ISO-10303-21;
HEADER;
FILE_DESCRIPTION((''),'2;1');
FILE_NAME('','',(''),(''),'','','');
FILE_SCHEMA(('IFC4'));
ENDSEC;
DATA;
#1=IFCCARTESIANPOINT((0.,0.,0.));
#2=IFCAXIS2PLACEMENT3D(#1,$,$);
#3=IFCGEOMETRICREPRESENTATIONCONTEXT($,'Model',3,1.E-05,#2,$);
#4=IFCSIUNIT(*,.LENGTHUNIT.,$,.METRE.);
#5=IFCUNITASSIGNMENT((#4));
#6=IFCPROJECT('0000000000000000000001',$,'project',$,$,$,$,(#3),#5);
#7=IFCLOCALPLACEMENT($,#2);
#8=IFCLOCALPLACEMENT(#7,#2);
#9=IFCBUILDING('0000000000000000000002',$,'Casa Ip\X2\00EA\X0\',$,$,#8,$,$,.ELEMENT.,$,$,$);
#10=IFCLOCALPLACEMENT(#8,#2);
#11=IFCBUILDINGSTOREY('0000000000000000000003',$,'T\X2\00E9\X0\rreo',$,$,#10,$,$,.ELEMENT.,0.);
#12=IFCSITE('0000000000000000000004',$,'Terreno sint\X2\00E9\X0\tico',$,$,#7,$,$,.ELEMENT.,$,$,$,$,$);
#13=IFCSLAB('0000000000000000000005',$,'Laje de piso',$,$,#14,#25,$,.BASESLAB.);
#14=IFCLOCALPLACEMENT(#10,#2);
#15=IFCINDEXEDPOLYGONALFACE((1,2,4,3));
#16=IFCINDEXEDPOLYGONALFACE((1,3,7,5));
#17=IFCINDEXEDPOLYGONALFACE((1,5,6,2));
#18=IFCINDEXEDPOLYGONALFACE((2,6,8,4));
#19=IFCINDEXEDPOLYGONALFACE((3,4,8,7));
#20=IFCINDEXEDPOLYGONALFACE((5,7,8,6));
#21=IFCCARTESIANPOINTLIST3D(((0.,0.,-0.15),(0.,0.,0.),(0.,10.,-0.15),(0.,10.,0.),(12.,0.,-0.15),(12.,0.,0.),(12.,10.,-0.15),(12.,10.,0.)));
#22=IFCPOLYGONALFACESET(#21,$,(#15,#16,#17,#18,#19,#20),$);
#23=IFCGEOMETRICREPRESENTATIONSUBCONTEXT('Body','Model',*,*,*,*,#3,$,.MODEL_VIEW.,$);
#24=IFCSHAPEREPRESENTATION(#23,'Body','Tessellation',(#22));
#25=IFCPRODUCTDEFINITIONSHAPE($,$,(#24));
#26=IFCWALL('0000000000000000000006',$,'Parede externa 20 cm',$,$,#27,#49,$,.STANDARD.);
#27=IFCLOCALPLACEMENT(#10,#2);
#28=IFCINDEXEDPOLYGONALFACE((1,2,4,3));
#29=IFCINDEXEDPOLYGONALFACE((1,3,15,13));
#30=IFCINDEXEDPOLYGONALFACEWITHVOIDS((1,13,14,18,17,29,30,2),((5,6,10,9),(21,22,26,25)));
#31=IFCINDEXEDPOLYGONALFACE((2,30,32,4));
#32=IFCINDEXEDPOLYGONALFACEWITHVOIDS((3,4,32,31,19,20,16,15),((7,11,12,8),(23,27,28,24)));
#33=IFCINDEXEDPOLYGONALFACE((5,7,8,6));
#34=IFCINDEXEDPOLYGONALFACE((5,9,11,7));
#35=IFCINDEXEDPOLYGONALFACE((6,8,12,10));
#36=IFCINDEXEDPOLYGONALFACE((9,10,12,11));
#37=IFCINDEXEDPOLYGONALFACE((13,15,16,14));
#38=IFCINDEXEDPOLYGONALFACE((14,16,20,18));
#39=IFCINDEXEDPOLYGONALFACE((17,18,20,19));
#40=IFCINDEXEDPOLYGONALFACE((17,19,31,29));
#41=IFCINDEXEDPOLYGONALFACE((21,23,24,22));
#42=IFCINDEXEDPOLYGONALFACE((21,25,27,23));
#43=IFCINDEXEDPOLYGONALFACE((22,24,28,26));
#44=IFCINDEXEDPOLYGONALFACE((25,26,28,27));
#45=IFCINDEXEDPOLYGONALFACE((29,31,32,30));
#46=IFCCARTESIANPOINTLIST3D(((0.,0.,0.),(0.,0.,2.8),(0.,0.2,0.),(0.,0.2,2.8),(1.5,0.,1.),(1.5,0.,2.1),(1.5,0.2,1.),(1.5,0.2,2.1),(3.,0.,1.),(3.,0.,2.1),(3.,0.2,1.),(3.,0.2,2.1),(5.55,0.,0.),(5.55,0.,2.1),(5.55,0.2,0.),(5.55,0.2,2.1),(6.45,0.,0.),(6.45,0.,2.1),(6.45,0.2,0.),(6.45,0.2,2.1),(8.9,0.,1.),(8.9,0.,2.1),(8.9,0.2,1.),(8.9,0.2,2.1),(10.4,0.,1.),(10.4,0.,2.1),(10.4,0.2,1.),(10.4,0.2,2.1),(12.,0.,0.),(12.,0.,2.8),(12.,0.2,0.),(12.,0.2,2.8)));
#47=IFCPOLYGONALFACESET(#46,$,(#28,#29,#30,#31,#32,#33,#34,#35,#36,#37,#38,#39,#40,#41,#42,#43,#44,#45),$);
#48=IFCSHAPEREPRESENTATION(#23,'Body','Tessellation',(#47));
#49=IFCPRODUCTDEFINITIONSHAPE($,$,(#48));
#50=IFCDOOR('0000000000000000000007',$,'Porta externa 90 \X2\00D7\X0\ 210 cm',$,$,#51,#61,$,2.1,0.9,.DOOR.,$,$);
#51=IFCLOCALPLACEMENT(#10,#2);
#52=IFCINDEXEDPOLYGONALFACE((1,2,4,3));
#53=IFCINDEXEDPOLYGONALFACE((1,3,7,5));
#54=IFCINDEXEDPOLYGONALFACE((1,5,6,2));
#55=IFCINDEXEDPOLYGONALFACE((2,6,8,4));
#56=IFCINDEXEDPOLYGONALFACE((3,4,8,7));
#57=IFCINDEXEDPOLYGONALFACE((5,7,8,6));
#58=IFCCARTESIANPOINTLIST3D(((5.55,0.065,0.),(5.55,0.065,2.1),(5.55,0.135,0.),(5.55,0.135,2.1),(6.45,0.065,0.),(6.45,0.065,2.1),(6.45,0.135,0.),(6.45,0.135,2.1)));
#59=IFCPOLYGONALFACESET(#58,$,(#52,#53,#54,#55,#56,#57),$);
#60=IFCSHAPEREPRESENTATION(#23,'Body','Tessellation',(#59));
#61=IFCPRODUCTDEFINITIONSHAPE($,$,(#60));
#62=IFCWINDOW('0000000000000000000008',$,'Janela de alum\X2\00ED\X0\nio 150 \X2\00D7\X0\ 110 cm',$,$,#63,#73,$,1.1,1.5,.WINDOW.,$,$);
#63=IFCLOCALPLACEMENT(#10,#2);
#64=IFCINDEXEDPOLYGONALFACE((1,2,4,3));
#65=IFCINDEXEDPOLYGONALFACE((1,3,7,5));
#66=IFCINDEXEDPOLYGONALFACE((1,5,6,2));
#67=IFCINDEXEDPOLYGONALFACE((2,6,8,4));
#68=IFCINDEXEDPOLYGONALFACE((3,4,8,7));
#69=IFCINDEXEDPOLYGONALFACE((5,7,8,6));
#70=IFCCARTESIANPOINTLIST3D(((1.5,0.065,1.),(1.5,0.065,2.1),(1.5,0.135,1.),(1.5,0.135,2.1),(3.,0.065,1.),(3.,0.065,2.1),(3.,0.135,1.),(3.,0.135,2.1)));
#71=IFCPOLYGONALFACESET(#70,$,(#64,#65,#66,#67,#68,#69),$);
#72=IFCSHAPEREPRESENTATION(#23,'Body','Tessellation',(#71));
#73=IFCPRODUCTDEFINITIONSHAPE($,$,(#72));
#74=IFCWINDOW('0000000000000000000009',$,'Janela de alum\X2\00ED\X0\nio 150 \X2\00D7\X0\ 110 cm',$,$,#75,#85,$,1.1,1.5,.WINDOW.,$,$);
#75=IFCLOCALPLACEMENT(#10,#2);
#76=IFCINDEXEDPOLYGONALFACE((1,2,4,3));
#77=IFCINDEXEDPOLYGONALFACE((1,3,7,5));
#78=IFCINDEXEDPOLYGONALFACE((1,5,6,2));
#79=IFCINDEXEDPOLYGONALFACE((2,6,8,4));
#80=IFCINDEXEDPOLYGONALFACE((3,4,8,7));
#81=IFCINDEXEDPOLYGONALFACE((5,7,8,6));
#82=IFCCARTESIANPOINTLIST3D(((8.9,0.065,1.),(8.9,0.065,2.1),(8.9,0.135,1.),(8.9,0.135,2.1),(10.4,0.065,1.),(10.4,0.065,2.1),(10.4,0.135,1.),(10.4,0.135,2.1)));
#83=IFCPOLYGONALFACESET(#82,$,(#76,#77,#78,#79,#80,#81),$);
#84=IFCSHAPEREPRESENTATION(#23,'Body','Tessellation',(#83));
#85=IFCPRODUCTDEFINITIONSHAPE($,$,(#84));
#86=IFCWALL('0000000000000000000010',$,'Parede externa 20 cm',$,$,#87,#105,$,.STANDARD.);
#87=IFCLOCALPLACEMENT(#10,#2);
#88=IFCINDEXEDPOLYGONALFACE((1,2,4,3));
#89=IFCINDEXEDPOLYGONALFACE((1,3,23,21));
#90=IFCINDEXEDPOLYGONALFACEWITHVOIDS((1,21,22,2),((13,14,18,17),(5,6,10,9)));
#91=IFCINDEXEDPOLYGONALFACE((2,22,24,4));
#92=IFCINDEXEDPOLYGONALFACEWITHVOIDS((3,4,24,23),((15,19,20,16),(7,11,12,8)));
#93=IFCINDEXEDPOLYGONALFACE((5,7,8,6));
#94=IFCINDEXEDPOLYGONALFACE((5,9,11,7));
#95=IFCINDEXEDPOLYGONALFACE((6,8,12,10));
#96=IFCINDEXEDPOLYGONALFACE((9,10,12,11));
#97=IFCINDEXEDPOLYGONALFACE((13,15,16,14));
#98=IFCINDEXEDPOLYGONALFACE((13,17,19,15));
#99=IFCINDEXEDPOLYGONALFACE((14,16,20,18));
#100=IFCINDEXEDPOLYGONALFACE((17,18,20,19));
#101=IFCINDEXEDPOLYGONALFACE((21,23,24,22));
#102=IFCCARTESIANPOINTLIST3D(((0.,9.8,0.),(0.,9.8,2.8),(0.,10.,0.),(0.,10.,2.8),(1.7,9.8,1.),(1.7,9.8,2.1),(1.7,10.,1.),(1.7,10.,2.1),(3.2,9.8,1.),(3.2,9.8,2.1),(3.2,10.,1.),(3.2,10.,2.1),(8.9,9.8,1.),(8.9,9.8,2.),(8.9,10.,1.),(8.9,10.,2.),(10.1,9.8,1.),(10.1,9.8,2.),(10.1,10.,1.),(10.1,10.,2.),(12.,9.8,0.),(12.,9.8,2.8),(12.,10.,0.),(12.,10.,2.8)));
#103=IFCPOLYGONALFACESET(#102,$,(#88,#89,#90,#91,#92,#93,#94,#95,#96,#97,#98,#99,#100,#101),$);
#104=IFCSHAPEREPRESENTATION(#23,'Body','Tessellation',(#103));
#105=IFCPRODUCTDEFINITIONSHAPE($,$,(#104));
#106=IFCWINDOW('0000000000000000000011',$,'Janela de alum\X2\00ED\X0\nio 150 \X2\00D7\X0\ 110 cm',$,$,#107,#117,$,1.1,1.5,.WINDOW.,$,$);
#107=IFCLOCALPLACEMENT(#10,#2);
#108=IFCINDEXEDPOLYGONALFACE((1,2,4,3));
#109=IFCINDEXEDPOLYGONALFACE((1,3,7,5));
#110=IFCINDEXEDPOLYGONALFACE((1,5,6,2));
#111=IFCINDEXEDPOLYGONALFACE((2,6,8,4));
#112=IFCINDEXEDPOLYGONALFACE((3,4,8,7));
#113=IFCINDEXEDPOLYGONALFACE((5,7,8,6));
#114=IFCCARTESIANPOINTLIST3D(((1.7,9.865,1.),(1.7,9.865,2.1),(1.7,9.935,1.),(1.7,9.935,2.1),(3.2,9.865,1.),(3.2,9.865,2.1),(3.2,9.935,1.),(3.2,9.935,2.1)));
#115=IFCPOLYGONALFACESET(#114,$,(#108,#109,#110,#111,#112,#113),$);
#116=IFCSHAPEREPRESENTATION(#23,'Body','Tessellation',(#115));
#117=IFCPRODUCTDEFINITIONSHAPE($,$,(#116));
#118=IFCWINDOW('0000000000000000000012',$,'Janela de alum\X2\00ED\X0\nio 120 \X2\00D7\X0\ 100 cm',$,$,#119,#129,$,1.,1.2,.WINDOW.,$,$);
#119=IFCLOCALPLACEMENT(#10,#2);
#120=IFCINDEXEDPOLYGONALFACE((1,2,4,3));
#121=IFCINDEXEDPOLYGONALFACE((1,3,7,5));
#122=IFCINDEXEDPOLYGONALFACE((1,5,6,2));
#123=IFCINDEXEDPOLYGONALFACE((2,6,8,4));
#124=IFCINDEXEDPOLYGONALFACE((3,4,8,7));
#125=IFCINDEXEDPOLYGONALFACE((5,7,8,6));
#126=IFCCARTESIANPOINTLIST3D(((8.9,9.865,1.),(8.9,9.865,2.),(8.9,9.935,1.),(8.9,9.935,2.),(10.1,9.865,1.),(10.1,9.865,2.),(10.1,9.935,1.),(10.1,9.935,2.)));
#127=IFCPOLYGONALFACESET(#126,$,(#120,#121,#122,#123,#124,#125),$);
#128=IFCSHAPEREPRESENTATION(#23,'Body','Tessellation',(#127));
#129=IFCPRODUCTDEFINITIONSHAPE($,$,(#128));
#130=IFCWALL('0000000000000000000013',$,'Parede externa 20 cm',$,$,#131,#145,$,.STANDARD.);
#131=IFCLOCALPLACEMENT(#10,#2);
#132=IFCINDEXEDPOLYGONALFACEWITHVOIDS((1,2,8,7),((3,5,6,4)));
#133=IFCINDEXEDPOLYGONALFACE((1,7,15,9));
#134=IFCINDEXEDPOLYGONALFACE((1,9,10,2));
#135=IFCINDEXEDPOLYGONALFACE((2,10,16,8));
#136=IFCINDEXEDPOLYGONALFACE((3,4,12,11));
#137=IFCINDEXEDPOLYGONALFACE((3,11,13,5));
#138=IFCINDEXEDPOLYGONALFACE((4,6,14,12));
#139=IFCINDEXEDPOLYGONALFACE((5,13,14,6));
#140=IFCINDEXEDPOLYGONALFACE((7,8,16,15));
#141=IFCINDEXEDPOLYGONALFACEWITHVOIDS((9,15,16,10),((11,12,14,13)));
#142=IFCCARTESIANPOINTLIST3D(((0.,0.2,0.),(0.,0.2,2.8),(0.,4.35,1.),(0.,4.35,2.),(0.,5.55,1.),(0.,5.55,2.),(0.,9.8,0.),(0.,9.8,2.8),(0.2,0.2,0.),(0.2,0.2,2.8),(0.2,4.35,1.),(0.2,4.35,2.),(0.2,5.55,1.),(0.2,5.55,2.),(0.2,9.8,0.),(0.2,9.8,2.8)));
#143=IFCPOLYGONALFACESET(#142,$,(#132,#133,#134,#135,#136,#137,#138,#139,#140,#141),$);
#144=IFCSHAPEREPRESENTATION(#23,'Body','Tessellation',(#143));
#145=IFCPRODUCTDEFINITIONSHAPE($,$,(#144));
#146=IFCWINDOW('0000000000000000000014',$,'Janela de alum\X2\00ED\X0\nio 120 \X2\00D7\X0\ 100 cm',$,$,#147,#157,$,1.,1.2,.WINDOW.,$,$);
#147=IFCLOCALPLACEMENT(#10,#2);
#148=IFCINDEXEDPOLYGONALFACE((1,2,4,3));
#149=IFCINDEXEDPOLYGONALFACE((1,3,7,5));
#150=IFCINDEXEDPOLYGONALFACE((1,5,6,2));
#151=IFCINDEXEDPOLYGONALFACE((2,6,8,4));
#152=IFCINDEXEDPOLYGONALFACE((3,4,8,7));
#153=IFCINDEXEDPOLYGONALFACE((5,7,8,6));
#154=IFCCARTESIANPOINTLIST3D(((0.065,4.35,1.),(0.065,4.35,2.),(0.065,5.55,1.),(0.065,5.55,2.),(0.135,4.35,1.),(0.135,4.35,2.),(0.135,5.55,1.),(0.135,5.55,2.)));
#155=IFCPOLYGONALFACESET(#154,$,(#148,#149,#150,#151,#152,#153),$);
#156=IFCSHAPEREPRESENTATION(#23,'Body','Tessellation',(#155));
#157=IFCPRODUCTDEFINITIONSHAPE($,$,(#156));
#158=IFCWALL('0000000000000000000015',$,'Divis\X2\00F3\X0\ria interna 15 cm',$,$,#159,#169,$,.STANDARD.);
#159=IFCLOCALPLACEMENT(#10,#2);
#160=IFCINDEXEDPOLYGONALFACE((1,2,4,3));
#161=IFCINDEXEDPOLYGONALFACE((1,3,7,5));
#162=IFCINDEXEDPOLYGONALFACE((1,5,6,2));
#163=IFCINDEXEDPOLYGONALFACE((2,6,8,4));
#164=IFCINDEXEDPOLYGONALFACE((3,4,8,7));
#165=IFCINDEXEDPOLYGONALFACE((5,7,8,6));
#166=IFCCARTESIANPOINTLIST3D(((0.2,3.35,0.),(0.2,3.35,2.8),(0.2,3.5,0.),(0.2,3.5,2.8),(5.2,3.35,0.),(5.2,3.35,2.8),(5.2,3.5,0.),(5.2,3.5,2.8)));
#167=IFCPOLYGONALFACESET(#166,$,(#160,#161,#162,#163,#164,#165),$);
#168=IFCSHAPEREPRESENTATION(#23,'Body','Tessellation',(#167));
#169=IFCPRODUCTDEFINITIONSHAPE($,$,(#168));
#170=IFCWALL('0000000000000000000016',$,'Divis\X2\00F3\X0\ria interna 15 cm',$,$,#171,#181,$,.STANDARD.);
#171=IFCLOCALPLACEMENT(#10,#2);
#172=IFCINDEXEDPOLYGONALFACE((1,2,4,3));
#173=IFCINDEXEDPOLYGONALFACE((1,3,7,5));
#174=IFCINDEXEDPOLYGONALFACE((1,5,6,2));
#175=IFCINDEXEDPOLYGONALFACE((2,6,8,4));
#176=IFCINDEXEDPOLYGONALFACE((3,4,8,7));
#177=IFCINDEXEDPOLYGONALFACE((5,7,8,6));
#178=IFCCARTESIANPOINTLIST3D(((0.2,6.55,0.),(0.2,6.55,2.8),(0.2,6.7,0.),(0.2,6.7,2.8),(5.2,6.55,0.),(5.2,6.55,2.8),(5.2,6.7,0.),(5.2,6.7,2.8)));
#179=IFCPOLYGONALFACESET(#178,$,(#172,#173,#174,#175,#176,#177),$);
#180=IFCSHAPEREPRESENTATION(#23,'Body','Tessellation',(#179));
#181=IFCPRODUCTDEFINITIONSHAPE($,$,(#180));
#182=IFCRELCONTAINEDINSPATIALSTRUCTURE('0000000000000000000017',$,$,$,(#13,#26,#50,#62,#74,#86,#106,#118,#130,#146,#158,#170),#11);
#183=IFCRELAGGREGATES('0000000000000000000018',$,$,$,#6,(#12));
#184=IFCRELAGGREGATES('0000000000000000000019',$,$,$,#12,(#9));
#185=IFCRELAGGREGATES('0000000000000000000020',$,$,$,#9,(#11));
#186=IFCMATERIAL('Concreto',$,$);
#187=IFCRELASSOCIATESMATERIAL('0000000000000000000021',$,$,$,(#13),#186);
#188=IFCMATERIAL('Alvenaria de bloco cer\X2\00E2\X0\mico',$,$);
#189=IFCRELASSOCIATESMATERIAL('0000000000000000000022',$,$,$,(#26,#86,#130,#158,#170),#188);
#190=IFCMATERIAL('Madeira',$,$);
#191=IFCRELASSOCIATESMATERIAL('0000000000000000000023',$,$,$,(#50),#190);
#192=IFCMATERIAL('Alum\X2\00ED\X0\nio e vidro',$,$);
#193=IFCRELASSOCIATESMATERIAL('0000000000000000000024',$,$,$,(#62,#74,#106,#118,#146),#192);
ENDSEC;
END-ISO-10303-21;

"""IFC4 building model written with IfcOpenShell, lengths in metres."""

from ifc_helpers import new_model, si_unit, frame, frame_2d, origin, place, context, subcontext, project, spatial, rectangle, extrude, material, element, fill, save


model = new_model("IFC4")

# Units and contexts
model_context = context("Model", 3, precision=1e-05, world=origin())
body_context = subcontext(model_context, "Body", "Model", "MODEL_VIEW")
ifc_project = project(units=[si_unit("LENGTHUNIT", "METRE")], contexts=[model_context])

# Site, building, storey
site_placement = place(None, origin())
site = spatial("IfcSite", under=ifc_project, at=site_placement, Name="Terreno sintético", CompositionType="ELEMENT")
building_placement = place(site_placement, origin())
building = spatial("IfcBuilding", under=site, at=building_placement, Name="Casa Ipê", CompositionType="ELEMENT")
storey_placement = place(building_placement, origin())
storey = spatial("IfcBuildingStorey", under=building, at=storey_placement, Name="Térreo", CompositionType="ELEMENT", Elevation=0.0)

# Slab
ifc_material_1 = material(Name="Concreto")
slab_placement = place(storey_placement, frame((0.0, 0.0, -0.15)))
element("IfcSlab", 1, at=slab_placement, inside=storey, material=ifc_material_1, Name="Laje de piso", PredefinedType="BASESLAB", context=body_context, shape_type="SweptSolid", body=[
    extrude(rectangle(XDim=12.0, YDim=10.0, at=frame_2d((6.0, 5.0))), origin(), (0.0, 0.0, 1.0), 0.15),
])

# Wall, openings, door, windows
ifc_material_2 = material(Name="Alvenaria de bloco cerâmico")
wall_1_placement = place(storey_placement, origin())
wall_1 = element("IfcWall", 2, at=wall_1_placement, inside=storey, material=ifc_material_2, Name="Parede externa 20 cm", PredefinedType="STANDARD", context=body_context, shape_type="SweptSolid", body=[
    extrude(rectangle(XDim=12.0, YDim=0.2, at=frame_2d((6.0, 0.1))), origin(), (0.0, 0.0, 1.0), 2.8),
])
opening_1_placement = place(wall_1_placement, frame((5.55, -0.01, 0.0)))
opening_1 = element("IfcOpeningElement", 3, at=opening_1_placement, cuts=wall_1, PredefinedType="OPENING", context=body_context, shape_type="SweptSolid", body=[
    extrude(rectangle(XDim=0.9, YDim=0.22, at=frame_2d((0.45, 0.11))), origin(), (0.0, 0.0, 1.0), 2.1),
])
opening_2_placement = place(wall_1_placement, frame((1.5, -0.01, 1.0)))
opening_2 = element("IfcOpeningElement", 4, at=opening_2_placement, cuts=wall_1, PredefinedType="OPENING", context=body_context, shape_type="SweptSolid", body=[
    extrude(rectangle(XDim=1.5, YDim=0.22, at=frame_2d((0.75, 0.11))), origin(), (0.0, 0.0, 1.0), 1.1),
])
opening_3_placement = place(wall_1_placement, frame((8.9, -0.01, 1.0)))
opening_3 = element("IfcOpeningElement", 5, at=opening_3_placement, cuts=wall_1, PredefinedType="OPENING", context=body_context, shape_type="SweptSolid", body=[
    extrude(rectangle(XDim=1.5, YDim=0.22, at=frame_2d((0.75, 0.11))), origin(), (0.0, 0.0, 1.0), 1.1),
])
ifc_material_3 = material(Name="Madeira")
door_placement = place(storey_placement, frame((5.55, 0.065, 0.0)))
door = element("IfcDoor", 6, at=door_placement, inside=storey, material=ifc_material_3, Name="Porta externa 90 × 210 cm", OverallHeight=2.1, OverallWidth=0.9, PredefinedType="DOOR", context=body_context, shape_type="SweptSolid", body=[
    extrude(rectangle(XDim=0.9, YDim=0.07, at=frame_2d((0.45, 0.035))), origin(), (0.0, 0.0, 1.0), 2.1),
])
fill(opening_1, door)
ifc_material_4 = material(Name="Alumínio e vidro")
window_1_placement = place(storey_placement, frame((1.5, 0.065, 1.0)))
window_1 = element("IfcWindow", 7, at=window_1_placement, inside=storey, material=ifc_material_4, Name="Janela de alumínio 150 × 110 cm", OverallHeight=1.1, OverallWidth=1.5, PredefinedType="WINDOW", context=body_context, shape_type="SweptSolid", body=[
    extrude(rectangle(XDim=1.5, YDim=0.07, at=frame_2d((0.75, 0.035))), origin(), (0.0, 0.0, 1.0), 1.1),
])
fill(opening_2, window_1)
window_2_placement = place(storey_placement, frame((8.9, 0.065, 1.0)))
window_2 = element("IfcWindow", 8, at=window_2_placement, inside=storey, material=ifc_material_4, Name="Janela de alumínio 150 × 110 cm", OverallHeight=1.1, OverallWidth=1.5, PredefinedType="WINDOW", context=body_context, shape_type="SweptSolid", body=[
    extrude(rectangle(XDim=1.5, YDim=0.07, at=frame_2d((0.75, 0.035))), origin(), (0.0, 0.0, 1.0), 1.1),
])
fill(opening_3, window_2)

# Wall, openings, windows
wall_2_placement = place(storey_placement, frame((0.0, 9.8, 0.0)))
wall_2 = element("IfcWall", 9, at=wall_2_placement, inside=storey, material=ifc_material_2, Name="Parede externa 20 cm", PredefinedType="STANDARD", context=body_context, shape_type="SweptSolid", body=[
    extrude(rectangle(XDim=12.0, YDim=0.2, at=frame_2d((6.0, 0.1))), origin(), (0.0, 0.0, 1.0), 2.8),
])
opening_4_placement = place(wall_2_placement, frame((1.7, -0.01, 1.0)))
opening_4 = element("IfcOpeningElement", 10, at=opening_4_placement, cuts=wall_2, PredefinedType="OPENING", context=body_context, shape_type="SweptSolid", body=[
    extrude(rectangle(XDim=1.5, YDim=0.22, at=frame_2d((0.75, 0.11))), origin(), (0.0, 0.0, 1.0), 1.1),
])
opening_5_placement = place(wall_2_placement, frame((8.9, -0.01, 1.0)))
opening_5 = element("IfcOpeningElement", 11, at=opening_5_placement, cuts=wall_2, PredefinedType="OPENING", context=body_context, shape_type="SweptSolid", body=[
    extrude(rectangle(XDim=1.2, YDim=0.22, at=frame_2d((0.6, 0.11))), origin(), (0.0, 0.0, 1.0), 1.0),
])
window_3_placement = place(storey_placement, frame((1.7, 9.865, 1.0)))
window_3 = element("IfcWindow", 12, at=window_3_placement, inside=storey, material=ifc_material_4, Name="Janela de alumínio 150 × 110 cm", OverallHeight=1.1, OverallWidth=1.5, PredefinedType="WINDOW", context=body_context, shape_type="SweptSolid", body=[
    extrude(rectangle(XDim=1.5, YDim=0.07, at=frame_2d((0.75, 0.035))), origin(), (0.0, 0.0, 1.0), 1.1),
])
fill(opening_4, window_3)
window_4_placement = place(storey_placement, frame((8.9, 9.865, 1.0)))
window_4 = element("IfcWindow", 13, at=window_4_placement, inside=storey, material=ifc_material_4, Name="Janela de alumínio 120 × 100 cm", OverallHeight=1.0, OverallWidth=1.2, PredefinedType="WINDOW", context=body_context, shape_type="SweptSolid", body=[
    extrude(rectangle(XDim=1.2, YDim=0.07, at=frame_2d((0.6, 0.035))), origin(), (0.0, 0.0, 1.0), 1.0),
])
fill(opening_5, window_4)

# Wall, opening, window
wall_3_placement = place(storey_placement, frame((0.0, 0.2, 0.0)))
wall_3 = element("IfcWall", 14, at=wall_3_placement, inside=storey, material=ifc_material_2, Name="Parede externa 20 cm", PredefinedType="STANDARD", context=body_context, shape_type="SweptSolid", body=[
    extrude(rectangle(XDim=0.2, YDim=9.6, at=frame_2d((0.1, 4.8))), origin(), (0.0, 0.0, 1.0), 2.8),
])
opening_6_placement = place(wall_3_placement, frame((-0.01, 4.15, 1.0)))
opening_6 = element("IfcOpeningElement", 15, at=opening_6_placement, cuts=wall_3, PredefinedType="OPENING", context=body_context, shape_type="SweptSolid", body=[
    extrude(rectangle(XDim=0.22, YDim=1.2, at=frame_2d((0.11, 0.6))), origin(), (0.0, 0.0, 1.0), 1.0),
])
window_5_placement = place(storey_placement, frame((0.065, 4.35, 1.0)))
window_5 = element("IfcWindow", 16, at=window_5_placement, inside=storey, material=ifc_material_4, Name="Janela de alumínio 120 × 100 cm", OverallHeight=1.0, OverallWidth=1.2, PredefinedType="WINDOW", context=body_context, shape_type="SweptSolid", body=[
    extrude(rectangle(XDim=0.07, YDim=1.2, at=frame_2d((0.035, 0.6))), origin(), (0.0, 0.0, 1.0), 1.0),
])
fill(opening_6, window_5)

# Walls
for number, where, name in (
    (17, (0.2, 3.35, 0.0), "Divisória interna 15 cm"),
    (18, (0.2, 6.55, 0.0), "Divisória interna 15 cm"),
):
    element("IfcWall", number, at=place(storey_placement, frame(where)), inside=storey, material=ifc_material_2, Name=name, PredefinedType="STANDARD", context=body_context, shape_type="SweptSolid", body=[
        extrude(rectangle(XDim=5.0, YDim=0.15, at=frame_2d((2.5, 0.075))), origin(), (0.0, 0.0, 1.0), 2.8),
    ])

save(model, "model.ifc")
